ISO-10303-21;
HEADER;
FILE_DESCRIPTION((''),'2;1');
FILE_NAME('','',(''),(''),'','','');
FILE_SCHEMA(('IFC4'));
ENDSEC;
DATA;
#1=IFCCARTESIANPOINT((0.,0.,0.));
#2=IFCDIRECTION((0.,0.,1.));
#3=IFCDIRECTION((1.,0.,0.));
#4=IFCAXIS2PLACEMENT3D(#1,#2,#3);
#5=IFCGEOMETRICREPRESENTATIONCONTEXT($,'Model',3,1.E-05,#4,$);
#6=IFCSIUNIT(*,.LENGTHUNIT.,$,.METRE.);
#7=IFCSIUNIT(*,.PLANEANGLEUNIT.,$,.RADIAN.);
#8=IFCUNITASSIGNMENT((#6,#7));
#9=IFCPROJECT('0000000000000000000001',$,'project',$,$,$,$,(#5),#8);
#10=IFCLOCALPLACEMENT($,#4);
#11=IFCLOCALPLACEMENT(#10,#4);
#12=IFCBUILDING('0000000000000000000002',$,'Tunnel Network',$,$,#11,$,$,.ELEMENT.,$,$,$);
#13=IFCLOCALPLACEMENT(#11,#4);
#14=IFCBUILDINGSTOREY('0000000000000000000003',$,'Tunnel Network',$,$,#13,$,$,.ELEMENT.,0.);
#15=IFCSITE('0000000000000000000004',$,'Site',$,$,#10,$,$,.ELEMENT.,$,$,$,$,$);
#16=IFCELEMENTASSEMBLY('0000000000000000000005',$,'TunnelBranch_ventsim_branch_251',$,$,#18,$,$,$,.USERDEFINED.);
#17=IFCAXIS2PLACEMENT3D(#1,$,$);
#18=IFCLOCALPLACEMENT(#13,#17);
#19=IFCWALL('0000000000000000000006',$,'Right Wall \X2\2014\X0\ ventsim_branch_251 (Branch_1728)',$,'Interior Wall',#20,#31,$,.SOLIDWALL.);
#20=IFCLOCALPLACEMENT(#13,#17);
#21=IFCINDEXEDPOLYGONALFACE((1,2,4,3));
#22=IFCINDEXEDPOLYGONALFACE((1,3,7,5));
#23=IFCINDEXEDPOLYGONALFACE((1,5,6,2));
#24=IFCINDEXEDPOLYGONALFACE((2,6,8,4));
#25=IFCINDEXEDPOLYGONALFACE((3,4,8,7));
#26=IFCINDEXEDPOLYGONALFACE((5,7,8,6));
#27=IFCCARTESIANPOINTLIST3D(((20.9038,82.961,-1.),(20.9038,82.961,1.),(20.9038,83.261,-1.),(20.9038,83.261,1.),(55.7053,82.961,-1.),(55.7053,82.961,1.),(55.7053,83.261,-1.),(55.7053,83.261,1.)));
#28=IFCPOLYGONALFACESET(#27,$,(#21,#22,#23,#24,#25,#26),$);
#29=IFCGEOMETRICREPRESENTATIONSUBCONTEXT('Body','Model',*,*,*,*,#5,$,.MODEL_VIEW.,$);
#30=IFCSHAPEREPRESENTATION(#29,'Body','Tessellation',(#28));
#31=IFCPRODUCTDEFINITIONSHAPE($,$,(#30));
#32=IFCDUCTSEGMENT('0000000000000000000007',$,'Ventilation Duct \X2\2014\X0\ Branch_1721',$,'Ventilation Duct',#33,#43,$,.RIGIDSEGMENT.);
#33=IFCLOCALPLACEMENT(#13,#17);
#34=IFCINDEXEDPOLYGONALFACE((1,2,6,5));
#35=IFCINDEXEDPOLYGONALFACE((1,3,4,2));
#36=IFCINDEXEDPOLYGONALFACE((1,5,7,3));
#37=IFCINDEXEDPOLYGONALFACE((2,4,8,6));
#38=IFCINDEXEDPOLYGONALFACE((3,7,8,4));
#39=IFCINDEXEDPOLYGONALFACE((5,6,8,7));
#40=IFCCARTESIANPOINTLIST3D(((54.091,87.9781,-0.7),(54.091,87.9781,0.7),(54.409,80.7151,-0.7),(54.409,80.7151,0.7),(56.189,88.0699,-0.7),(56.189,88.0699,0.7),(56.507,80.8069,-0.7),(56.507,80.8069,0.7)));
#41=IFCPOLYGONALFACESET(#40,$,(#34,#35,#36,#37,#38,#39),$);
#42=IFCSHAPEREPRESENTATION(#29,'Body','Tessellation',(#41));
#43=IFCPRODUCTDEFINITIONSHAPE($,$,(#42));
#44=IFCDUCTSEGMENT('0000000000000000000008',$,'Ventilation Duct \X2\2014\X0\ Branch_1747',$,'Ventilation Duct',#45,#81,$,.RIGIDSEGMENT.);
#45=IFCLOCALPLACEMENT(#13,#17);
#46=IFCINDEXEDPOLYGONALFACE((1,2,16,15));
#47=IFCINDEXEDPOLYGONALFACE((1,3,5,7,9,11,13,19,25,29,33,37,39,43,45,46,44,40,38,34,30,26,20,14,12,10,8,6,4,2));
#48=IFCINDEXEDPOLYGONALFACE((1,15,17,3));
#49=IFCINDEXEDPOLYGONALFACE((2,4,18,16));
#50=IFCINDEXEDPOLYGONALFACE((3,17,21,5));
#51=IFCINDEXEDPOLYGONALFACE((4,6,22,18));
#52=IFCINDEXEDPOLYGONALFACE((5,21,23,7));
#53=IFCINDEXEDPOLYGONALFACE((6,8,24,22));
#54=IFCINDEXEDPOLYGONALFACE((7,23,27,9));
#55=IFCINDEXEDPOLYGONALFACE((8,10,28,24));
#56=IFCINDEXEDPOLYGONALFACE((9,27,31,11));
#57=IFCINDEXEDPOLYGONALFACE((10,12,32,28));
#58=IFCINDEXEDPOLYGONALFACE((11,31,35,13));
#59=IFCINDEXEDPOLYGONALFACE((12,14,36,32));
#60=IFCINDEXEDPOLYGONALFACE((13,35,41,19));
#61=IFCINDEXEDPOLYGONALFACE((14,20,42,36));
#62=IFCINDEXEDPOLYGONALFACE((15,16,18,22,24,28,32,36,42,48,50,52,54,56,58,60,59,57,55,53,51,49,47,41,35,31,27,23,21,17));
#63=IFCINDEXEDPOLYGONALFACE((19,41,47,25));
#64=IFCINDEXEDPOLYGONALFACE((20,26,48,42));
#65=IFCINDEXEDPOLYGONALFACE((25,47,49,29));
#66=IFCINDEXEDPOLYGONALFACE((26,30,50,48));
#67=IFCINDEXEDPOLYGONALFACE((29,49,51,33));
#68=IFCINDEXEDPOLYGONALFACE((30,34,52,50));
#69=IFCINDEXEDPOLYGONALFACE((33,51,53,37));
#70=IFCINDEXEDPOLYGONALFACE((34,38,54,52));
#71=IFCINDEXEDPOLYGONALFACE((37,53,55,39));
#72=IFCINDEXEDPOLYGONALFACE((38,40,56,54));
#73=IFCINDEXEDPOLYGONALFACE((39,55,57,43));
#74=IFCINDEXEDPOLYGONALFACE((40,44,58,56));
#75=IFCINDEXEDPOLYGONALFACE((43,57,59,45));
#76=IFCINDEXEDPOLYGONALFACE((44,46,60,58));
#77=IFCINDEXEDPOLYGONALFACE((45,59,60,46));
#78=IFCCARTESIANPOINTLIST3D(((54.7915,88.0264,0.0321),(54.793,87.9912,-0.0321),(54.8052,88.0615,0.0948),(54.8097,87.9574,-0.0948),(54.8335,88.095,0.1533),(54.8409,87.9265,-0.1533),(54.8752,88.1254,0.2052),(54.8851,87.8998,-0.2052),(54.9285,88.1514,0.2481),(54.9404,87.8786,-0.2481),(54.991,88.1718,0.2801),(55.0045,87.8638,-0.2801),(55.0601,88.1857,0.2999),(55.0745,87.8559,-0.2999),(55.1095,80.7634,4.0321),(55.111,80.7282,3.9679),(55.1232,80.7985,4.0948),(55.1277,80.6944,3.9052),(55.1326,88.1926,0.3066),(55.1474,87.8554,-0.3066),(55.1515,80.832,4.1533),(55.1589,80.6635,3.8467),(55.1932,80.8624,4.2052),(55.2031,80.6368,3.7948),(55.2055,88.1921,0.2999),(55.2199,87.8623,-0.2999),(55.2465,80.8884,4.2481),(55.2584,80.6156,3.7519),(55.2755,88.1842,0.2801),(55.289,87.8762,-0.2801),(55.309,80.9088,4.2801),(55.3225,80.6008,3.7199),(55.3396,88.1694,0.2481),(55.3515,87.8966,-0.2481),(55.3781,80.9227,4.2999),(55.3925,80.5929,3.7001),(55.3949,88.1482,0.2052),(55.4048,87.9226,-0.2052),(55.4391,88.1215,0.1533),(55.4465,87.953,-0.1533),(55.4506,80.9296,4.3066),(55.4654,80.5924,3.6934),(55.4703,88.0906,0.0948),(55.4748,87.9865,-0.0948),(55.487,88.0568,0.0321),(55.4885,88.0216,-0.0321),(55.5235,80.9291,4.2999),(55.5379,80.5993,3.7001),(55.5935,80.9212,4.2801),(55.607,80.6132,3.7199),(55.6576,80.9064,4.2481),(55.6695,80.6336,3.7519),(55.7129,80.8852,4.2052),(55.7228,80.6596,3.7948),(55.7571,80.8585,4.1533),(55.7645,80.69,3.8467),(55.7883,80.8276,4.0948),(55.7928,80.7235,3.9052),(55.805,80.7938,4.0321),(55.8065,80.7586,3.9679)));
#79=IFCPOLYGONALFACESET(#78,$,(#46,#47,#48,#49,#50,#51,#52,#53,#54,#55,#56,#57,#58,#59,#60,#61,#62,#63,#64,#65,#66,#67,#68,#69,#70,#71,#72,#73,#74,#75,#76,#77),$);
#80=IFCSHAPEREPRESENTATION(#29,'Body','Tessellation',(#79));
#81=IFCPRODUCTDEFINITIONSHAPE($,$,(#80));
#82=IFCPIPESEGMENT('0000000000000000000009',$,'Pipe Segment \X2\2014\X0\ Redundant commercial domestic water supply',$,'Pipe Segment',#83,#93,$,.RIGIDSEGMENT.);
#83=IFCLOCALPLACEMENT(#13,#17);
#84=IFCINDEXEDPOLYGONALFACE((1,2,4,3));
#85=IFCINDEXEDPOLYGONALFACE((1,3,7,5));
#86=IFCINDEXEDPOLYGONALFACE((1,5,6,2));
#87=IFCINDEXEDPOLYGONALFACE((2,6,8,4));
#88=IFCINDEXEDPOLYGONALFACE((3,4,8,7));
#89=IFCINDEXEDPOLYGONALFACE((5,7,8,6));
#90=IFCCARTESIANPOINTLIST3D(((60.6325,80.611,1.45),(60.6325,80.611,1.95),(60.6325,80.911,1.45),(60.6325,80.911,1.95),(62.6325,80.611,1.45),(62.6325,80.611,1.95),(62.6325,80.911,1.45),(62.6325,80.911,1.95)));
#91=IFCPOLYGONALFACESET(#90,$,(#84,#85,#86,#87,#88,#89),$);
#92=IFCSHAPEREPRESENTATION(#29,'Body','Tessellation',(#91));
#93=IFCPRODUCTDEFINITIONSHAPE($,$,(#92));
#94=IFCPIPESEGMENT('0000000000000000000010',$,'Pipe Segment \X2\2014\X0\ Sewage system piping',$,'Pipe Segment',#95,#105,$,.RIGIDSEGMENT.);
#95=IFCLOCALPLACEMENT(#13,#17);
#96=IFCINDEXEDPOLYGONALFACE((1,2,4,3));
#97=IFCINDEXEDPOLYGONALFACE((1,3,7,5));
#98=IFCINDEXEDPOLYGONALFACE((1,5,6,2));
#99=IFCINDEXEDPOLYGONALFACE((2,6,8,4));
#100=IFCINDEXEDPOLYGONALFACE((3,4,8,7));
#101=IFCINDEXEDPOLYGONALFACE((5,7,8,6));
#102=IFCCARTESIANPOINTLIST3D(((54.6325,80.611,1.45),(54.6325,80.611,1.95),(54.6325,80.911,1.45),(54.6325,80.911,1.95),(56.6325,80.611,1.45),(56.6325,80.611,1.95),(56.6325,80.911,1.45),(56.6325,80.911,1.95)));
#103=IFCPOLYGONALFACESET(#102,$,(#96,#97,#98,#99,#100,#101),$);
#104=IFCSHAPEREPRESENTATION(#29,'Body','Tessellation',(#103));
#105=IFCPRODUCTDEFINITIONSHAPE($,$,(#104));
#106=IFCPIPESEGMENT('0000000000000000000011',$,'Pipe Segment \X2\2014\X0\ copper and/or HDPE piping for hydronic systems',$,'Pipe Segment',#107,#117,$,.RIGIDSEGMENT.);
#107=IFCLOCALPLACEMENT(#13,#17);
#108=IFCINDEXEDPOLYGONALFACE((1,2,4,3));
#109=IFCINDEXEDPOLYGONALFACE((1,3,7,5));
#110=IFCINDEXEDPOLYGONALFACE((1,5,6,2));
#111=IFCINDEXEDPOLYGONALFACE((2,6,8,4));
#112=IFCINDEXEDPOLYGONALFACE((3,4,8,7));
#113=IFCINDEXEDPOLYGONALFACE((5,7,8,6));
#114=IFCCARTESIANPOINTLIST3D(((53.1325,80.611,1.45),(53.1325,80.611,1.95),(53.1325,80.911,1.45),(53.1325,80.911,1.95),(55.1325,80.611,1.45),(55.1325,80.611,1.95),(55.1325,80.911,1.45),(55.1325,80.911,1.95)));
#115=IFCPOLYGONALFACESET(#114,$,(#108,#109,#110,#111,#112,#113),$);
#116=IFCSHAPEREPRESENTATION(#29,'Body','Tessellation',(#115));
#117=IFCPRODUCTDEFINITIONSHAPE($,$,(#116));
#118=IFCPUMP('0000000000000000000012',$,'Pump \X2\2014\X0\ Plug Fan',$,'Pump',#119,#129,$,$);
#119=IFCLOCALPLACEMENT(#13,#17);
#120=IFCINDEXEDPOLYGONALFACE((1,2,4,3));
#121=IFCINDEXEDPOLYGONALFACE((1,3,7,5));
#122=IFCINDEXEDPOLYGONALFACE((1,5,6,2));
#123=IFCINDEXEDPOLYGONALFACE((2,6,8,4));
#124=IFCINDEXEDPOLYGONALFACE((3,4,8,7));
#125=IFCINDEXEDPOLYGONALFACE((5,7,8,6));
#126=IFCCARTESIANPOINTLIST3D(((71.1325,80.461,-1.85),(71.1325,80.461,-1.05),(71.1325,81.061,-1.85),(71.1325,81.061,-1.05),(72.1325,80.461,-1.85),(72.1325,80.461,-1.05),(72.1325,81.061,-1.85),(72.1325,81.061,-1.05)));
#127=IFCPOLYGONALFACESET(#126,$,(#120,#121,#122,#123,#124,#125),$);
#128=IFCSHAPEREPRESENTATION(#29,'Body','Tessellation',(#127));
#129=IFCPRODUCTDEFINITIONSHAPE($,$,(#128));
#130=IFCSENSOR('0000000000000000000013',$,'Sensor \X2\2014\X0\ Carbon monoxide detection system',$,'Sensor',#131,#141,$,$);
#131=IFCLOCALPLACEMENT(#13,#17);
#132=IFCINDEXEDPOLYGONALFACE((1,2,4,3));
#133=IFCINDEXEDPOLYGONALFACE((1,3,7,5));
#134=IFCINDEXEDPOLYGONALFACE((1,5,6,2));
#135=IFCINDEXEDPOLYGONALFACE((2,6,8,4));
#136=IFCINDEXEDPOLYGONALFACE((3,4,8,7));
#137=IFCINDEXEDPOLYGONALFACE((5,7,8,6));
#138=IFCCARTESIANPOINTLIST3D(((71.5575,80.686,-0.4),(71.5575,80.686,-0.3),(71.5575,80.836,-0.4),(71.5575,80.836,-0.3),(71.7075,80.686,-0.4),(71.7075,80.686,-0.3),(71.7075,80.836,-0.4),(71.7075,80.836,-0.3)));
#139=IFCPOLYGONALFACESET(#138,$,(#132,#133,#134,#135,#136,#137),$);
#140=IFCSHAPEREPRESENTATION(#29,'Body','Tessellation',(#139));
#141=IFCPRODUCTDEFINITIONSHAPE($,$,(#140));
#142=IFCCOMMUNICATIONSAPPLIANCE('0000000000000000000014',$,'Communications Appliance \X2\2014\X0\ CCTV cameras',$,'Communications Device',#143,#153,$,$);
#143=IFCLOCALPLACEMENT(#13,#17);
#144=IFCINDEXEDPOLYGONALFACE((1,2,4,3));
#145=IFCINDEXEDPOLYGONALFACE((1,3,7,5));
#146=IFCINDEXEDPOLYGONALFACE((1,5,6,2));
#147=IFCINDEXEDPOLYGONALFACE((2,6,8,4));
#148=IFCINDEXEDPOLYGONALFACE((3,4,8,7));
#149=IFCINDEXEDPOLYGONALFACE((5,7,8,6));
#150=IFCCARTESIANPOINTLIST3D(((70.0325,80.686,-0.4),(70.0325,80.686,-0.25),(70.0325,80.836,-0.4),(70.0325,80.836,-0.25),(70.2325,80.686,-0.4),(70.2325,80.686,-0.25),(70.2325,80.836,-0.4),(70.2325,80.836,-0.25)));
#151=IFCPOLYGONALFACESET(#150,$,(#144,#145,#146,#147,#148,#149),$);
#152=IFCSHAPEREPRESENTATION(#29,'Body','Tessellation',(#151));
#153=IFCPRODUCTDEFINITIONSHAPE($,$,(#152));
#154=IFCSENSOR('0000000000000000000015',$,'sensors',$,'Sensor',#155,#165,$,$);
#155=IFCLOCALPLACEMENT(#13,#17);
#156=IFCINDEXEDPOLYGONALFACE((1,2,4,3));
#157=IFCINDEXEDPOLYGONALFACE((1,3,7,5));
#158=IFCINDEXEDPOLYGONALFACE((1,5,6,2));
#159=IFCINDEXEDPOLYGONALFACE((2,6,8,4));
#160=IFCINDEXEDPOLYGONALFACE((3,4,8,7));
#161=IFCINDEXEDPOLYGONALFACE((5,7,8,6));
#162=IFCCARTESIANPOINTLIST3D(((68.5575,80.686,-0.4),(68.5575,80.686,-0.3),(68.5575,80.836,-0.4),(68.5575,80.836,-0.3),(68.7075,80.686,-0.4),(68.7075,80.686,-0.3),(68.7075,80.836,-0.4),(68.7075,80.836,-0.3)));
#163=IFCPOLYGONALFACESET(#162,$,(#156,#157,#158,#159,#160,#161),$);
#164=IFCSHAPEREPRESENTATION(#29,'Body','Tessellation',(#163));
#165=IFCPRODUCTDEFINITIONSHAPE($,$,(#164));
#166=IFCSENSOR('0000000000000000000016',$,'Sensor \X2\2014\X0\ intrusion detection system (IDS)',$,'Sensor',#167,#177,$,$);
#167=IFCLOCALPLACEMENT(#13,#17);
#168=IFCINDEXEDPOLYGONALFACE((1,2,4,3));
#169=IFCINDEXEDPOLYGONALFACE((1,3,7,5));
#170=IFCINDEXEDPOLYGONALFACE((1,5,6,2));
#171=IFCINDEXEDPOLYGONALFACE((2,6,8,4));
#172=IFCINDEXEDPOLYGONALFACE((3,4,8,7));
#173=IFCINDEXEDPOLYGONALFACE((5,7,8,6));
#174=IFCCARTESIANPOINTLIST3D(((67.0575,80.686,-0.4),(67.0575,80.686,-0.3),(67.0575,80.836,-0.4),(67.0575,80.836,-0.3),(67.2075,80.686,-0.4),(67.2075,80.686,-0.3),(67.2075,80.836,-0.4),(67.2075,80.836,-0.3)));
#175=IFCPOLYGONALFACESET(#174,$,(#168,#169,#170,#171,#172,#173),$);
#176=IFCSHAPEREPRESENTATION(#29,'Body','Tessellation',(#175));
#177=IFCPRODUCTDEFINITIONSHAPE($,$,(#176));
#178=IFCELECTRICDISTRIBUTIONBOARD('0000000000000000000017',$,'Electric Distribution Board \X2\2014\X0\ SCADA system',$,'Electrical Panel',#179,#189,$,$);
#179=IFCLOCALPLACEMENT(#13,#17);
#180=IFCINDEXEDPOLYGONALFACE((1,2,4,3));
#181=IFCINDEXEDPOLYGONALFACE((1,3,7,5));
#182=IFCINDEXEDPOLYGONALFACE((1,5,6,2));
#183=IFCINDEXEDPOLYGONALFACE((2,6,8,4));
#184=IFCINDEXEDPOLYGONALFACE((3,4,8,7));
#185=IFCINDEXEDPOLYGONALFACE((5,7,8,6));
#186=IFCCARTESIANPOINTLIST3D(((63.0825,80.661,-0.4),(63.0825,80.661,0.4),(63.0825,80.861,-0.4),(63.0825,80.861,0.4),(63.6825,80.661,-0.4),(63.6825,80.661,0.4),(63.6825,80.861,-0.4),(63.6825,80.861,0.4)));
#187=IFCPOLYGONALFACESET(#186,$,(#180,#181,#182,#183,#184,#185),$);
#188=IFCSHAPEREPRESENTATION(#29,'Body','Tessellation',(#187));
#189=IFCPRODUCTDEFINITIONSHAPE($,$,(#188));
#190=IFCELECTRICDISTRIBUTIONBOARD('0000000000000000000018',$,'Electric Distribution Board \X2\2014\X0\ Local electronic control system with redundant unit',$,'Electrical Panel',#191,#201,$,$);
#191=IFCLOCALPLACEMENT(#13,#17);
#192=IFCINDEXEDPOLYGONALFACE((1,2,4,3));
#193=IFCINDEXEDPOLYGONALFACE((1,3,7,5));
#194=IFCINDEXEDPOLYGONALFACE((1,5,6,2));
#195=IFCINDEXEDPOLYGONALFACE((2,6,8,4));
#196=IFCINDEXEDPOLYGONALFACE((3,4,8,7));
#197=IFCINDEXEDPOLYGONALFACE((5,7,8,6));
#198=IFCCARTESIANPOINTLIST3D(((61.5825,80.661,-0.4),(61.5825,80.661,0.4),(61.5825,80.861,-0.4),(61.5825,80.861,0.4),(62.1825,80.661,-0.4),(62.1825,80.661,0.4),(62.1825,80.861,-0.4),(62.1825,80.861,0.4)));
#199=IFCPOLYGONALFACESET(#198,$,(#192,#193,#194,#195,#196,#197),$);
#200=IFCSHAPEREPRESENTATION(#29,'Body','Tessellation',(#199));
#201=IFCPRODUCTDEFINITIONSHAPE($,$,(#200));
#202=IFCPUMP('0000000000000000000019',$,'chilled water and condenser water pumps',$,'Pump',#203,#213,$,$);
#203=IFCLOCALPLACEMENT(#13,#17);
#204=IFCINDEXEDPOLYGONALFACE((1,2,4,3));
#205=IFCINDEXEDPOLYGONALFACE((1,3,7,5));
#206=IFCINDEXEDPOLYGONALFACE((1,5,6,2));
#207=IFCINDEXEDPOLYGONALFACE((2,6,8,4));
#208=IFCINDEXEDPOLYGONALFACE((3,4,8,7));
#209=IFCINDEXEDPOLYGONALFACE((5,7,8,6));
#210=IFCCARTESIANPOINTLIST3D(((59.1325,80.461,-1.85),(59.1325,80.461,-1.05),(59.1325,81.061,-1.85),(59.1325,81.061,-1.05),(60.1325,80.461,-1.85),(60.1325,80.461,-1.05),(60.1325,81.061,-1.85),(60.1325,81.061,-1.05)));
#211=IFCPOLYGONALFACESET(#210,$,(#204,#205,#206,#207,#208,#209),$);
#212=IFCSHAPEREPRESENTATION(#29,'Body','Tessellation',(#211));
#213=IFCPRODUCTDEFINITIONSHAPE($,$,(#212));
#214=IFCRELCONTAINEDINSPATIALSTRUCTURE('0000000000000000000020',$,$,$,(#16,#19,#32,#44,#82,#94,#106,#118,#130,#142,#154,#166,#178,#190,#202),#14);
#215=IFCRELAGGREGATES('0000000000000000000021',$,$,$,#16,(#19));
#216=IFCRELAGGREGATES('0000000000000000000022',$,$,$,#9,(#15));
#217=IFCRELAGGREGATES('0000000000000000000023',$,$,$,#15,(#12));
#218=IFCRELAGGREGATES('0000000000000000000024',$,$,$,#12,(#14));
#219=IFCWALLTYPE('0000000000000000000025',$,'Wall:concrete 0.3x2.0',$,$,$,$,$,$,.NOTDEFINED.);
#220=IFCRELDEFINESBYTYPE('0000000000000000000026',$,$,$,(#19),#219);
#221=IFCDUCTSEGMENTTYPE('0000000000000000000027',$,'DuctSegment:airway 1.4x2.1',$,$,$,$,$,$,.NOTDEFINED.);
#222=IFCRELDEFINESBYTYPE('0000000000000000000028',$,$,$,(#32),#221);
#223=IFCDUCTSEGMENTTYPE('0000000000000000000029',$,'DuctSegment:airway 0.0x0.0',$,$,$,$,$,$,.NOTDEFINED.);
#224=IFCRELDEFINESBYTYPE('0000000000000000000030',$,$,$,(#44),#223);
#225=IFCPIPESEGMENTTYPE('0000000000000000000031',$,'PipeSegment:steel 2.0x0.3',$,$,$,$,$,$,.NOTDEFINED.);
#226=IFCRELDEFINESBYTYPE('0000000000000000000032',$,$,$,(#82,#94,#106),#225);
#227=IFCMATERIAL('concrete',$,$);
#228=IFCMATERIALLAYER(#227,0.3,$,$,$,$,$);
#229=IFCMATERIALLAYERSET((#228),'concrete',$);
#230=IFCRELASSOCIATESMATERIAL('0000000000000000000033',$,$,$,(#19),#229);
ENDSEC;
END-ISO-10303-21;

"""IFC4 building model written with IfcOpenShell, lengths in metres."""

from ifc_helpers import new_model, si_unit, frame, origin_with_axes, origin_2d_with_axis, place, context, subcontext, project, spatial, rectangle, circle, extrude, material, layer, layer_set, layer_usage, type_object, element, aggregate, save


model = new_model("IFC4")

# Units and contexts
model_context = context("Model", 3, precision=1e-05, world=origin_with_axes())
body_context = subcontext(model_context, "Body", "Model", "MODEL_VIEW")
ifc_project = project(units=[si_unit("LENGTHUNIT", "METRE"), si_unit("PLANEANGLEUNIT", "RADIAN")], contexts=[model_context])

# Site, building, storey
site_placement = place(None, origin_with_axes())
site = spatial("IfcSite", under=ifc_project, at=site_placement, Name="Site", CompositionType="ELEMENT")
building_placement = place(site_placement, origin_with_axes())
building = spatial("IfcBuilding", under=site, at=building_placement, Name="Tunnel Network", CompositionType="ELEMENT")
storey_placement = place(building_placement, origin_with_axes())
storey = spatial("IfcBuildingStorey", under=building, at=storey_placement, Name="Tunnel Network", CompositionType="ELEMENT", Elevation=0.0)

# Element assembly
ifc_material = material(Name="concrete")
ifc_layer = layer(ifc_material, 0.3)
ifc_layer_set = layer_set([ifc_layer], Name="concrete")
assembly_1_placement = place(storey_placement, frame((55.7093, 78.411, 0.0), z_axis=(-1.0, 0.0, 0.0), x_axis=(0.0, 1.0, 0.0)))
assembly_1 = element("IfcElementAssembly", 1, at=assembly_1_placement, inside=storey, Name="TunnelBranch_ventsim_branch_251", PredefinedType="USERDEFINED")

# Wall
wall_type = type_object("IfcWallType", Name="Wall:concrete 0.3x2.0")
ifc_layer_usage_1 = layer_usage(ifc_layer_set, "AXIS2", "POSITIVE", 0.0)
wall_1_placement = place(storey_placement, frame((55.7053, 83.111, 0.0), z_axis=(-1.0, 0.0, 0.0), x_axis=(0.0, 1.0, 0.0)))
wall_1 = element("IfcWall", 2, at=wall_1_placement, inside=storey, type_object=wall_type, material=ifc_layer_usage_1, Name="Right Wall — ventsim_branch_251 (Branch_1728)", ObjectType="Interior Wall", PredefinedType="SOLIDWALL", context=body_context, shape_type="SweptSolid", body=[
    extrude(rectangle(XDim=0.3, YDim=2.0, at=origin_2d_with_axis()), origin_with_axes(), (0.0, 0.0, 1.0), 34.8015),
])
aggregate(assembly_1, [wall_1])

# Duct segments
duct_segment_type_1 = type_object("IfcDuctSegmentType", Name="DuctSegment:airway 1.4x2.1")
duct_segment_1_placement = place(storey_placement, frame((55.458, 80.761, 0.0), z_axis=(-0.043741, 0.999043, 0.0), x_axis=(0.0, 0.0, 1.0)))
element("IfcDuctSegment", 3, at=duct_segment_1_placement, inside=storey, type_object=duct_segment_type_1, Name="Ventilation Duct — Branch_1721", ObjectType="Ventilation Duct", PredefinedType="RIGIDSEGMENT", context=body_context, shape_type="SweptSolid", body=[
    extrude(rectangle(XDim=1.4, YDim=2.1, at=origin_2d_with_axis()), origin_with_axes(), (0.0, 0.0, 1.0), 7.27),
])
duct_segment_type_2 = type_object("IfcDuctSegmentType", Name="DuctSegment:airway 0.0x0.0")
duct_segment_2_placement = place(storey_placement, frame((55.458, 80.761, 4.0), z_axis=(-0.038324, 0.8753, -0.48206), x_axis=(-0.021086, 0.481598, 0.876138)))
element("IfcDuctSegment", 4, at=duct_segment_2_placement, inside=storey, type_object=duct_segment_type_2, Name="Ventilation Duct — Branch_1747", ObjectType="Ventilation Duct", PredefinedType="RIGIDSEGMENT", context=body_context, shape_type="SweptSolid", body=[
    extrude(circle(Radius=0.35, at=origin_2d_with_axis()), origin_with_axes(), (0.0, 0.0, 1.0), 8.2977),
])

# Pipe segments
pipe_segment_type = type_object("IfcPipeSegmentType", Name="PipeSegment:steel 2.0x0.3")
for number, where, z_axis, x_axis, name in (
    (5, (61.6325, 80.761, 1.45), (0.0, 0.0, 1.0), (1.0, 0.0, 0.0), "Pipe Segment — Redundant commercial domestic water supply"),
    (6, (55.6325, 80.761, 1.45), (0.0, 0.0, 1.0), (1.0, 0.0, 0.0), "Pipe Segment — Sewage system piping"),
    (7, (54.1325, 80.761, 1.45), (0.0, 0.0, 1.0), (1.0, 0.0, 0.0), "Pipe Segment — copper and/or HDPE piping for hydronic systems"),
):
    element("IfcPipeSegment", number, at=place(storey_placement, frame(where, z_axis=z_axis, x_axis=x_axis)), inside=storey, type_object=pipe_segment_type, Name=name, ObjectType="Pipe Segment", PredefinedType="RIGIDSEGMENT", context=body_context, shape_type="SweptSolid", body=[
        extrude(rectangle(XDim=2.0, YDim=0.3, at=origin_2d_with_axis()), origin_with_axes(), (0.0, 0.0, 1.0), 0.5),
    ])

# Pump
pump_placement = place(storey_placement, frame((71.6325, 80.761, -1.85), z_axis=(0.0, 0.0, 1.0), x_axis=(1.0, 0.0, 0.0)))
element("IfcPump", 8, at=pump_placement, inside=storey, Name="Pump — Plug Fan", ObjectType="Pump", context=body_context, shape_type="SweptSolid", body=[
    extrude(rectangle(XDim=1.0, YDim=0.6, at=origin_2d_with_axis()), origin_with_axes(), (0.0, 0.0, 1.0), 0.8),
])

# Sensor
sensor_placement = place(storey_placement, frame((71.6325, 80.761, -0.4), z_axis=(0.0, 0.0, 1.0), x_axis=(1.0, 0.0, 0.0)))
element("IfcSensor", 9, at=sensor_placement, inside=storey, Name="Sensor — Carbon monoxide detection system", ObjectType="Sensor", context=body_context, shape_type="SweptSolid", body=[
    extrude(rectangle(XDim=0.15, YDim=0.15, at=origin_2d_with_axis()), origin_with_axes(), (0.0, 0.0, 1.0), 0.1),
])

# Communications appliance
communications_appliance_placement = place(storey_placement, frame((70.1325, 80.761, -0.4), z_axis=(0.0, 0.0, 1.0), x_axis=(1.0, 0.0, 0.0)))
element("IfcCommunicationsAppliance", 10, at=communications_appliance_placement, inside=storey, Name="Communications Appliance — CCTV cameras", ObjectType="Communications Device", context=body_context, shape_type="SweptSolid", body=[
    extrude(rectangle(XDim=0.2, YDim=0.15, at=origin_2d_with_axis()), origin_with_axes(), (0.0, 0.0, 1.0), 0.15),
])

# Sensors
for number, where, z_axis, x_axis, name in (
    (11, (68.6325, 80.761, -0.4), (0.0, 0.0, 1.0), (1.0, 0.0, 0.0), "sensors"),
    (12, (67.1325, 80.761, -0.4), (0.0, 0.0, 1.0), (1.0, 0.0, 0.0), "Sensor — intrusion detection system (IDS)"),
):
    element("IfcSensor", number, at=place(storey_placement, frame(where, z_axis=z_axis, x_axis=x_axis)), inside=storey, Name=name, ObjectType="Sensor", context=body_context, shape_type="SweptSolid", body=[
        extrude(rectangle(XDim=0.15, YDim=0.15, at=origin_2d_with_axis()), origin_with_axes(), (0.0, 0.0, 1.0), 0.1),
    ])

# Electric distribution boards
for number, where, z_axis, x_axis, name in (
    (13, (63.3825, 80.761, -0.4), (0.0, 0.0, 1.0), (1.0, 0.0, 0.0), "Electric Distribution Board — SCADA system"),
    (14, (61.8825, 80.761, -0.4), (0.0, 0.0, 1.0), (1.0, 0.0, 0.0), "Electric Distribution Board — Local electronic control system with redundant unit"),
):
    element("IfcElectricDistributionBoard", number, at=place(storey_placement, frame(where, z_axis=z_axis, x_axis=x_axis)), inside=storey, Name=name, ObjectType="Electrical Panel", context=body_context, shape_type="SweptSolid", body=[
        extrude(rectangle(XDim=0.6, YDim=0.2, at=origin_2d_with_axis()), origin_with_axes(), (0.0, 0.0, 1.0), 0.8),
    ])

# Pump
for number, where, z_axis, x_axis, name in (
    (15, (59.6325, 80.761, -1.85), (0.0, 0.0, 1.0), (1.0, 0.0, 0.0), "chilled water and condenser water pumps"),
):
    element("IfcPump", number, at=place(storey_placement, frame(where, z_axis=z_axis, x_axis=x_axis)), inside=storey, Name=name, ObjectType="Pump", context=body_context, shape_type="SweptSolid", body=[
        extrude(rectangle(XDim=1.0, YDim=0.6, at=origin_2d_with_axis()), origin_with_axes(), (0.0, 0.0, 1.0), 0.8),
    ])

save(model, "model.ifc")
